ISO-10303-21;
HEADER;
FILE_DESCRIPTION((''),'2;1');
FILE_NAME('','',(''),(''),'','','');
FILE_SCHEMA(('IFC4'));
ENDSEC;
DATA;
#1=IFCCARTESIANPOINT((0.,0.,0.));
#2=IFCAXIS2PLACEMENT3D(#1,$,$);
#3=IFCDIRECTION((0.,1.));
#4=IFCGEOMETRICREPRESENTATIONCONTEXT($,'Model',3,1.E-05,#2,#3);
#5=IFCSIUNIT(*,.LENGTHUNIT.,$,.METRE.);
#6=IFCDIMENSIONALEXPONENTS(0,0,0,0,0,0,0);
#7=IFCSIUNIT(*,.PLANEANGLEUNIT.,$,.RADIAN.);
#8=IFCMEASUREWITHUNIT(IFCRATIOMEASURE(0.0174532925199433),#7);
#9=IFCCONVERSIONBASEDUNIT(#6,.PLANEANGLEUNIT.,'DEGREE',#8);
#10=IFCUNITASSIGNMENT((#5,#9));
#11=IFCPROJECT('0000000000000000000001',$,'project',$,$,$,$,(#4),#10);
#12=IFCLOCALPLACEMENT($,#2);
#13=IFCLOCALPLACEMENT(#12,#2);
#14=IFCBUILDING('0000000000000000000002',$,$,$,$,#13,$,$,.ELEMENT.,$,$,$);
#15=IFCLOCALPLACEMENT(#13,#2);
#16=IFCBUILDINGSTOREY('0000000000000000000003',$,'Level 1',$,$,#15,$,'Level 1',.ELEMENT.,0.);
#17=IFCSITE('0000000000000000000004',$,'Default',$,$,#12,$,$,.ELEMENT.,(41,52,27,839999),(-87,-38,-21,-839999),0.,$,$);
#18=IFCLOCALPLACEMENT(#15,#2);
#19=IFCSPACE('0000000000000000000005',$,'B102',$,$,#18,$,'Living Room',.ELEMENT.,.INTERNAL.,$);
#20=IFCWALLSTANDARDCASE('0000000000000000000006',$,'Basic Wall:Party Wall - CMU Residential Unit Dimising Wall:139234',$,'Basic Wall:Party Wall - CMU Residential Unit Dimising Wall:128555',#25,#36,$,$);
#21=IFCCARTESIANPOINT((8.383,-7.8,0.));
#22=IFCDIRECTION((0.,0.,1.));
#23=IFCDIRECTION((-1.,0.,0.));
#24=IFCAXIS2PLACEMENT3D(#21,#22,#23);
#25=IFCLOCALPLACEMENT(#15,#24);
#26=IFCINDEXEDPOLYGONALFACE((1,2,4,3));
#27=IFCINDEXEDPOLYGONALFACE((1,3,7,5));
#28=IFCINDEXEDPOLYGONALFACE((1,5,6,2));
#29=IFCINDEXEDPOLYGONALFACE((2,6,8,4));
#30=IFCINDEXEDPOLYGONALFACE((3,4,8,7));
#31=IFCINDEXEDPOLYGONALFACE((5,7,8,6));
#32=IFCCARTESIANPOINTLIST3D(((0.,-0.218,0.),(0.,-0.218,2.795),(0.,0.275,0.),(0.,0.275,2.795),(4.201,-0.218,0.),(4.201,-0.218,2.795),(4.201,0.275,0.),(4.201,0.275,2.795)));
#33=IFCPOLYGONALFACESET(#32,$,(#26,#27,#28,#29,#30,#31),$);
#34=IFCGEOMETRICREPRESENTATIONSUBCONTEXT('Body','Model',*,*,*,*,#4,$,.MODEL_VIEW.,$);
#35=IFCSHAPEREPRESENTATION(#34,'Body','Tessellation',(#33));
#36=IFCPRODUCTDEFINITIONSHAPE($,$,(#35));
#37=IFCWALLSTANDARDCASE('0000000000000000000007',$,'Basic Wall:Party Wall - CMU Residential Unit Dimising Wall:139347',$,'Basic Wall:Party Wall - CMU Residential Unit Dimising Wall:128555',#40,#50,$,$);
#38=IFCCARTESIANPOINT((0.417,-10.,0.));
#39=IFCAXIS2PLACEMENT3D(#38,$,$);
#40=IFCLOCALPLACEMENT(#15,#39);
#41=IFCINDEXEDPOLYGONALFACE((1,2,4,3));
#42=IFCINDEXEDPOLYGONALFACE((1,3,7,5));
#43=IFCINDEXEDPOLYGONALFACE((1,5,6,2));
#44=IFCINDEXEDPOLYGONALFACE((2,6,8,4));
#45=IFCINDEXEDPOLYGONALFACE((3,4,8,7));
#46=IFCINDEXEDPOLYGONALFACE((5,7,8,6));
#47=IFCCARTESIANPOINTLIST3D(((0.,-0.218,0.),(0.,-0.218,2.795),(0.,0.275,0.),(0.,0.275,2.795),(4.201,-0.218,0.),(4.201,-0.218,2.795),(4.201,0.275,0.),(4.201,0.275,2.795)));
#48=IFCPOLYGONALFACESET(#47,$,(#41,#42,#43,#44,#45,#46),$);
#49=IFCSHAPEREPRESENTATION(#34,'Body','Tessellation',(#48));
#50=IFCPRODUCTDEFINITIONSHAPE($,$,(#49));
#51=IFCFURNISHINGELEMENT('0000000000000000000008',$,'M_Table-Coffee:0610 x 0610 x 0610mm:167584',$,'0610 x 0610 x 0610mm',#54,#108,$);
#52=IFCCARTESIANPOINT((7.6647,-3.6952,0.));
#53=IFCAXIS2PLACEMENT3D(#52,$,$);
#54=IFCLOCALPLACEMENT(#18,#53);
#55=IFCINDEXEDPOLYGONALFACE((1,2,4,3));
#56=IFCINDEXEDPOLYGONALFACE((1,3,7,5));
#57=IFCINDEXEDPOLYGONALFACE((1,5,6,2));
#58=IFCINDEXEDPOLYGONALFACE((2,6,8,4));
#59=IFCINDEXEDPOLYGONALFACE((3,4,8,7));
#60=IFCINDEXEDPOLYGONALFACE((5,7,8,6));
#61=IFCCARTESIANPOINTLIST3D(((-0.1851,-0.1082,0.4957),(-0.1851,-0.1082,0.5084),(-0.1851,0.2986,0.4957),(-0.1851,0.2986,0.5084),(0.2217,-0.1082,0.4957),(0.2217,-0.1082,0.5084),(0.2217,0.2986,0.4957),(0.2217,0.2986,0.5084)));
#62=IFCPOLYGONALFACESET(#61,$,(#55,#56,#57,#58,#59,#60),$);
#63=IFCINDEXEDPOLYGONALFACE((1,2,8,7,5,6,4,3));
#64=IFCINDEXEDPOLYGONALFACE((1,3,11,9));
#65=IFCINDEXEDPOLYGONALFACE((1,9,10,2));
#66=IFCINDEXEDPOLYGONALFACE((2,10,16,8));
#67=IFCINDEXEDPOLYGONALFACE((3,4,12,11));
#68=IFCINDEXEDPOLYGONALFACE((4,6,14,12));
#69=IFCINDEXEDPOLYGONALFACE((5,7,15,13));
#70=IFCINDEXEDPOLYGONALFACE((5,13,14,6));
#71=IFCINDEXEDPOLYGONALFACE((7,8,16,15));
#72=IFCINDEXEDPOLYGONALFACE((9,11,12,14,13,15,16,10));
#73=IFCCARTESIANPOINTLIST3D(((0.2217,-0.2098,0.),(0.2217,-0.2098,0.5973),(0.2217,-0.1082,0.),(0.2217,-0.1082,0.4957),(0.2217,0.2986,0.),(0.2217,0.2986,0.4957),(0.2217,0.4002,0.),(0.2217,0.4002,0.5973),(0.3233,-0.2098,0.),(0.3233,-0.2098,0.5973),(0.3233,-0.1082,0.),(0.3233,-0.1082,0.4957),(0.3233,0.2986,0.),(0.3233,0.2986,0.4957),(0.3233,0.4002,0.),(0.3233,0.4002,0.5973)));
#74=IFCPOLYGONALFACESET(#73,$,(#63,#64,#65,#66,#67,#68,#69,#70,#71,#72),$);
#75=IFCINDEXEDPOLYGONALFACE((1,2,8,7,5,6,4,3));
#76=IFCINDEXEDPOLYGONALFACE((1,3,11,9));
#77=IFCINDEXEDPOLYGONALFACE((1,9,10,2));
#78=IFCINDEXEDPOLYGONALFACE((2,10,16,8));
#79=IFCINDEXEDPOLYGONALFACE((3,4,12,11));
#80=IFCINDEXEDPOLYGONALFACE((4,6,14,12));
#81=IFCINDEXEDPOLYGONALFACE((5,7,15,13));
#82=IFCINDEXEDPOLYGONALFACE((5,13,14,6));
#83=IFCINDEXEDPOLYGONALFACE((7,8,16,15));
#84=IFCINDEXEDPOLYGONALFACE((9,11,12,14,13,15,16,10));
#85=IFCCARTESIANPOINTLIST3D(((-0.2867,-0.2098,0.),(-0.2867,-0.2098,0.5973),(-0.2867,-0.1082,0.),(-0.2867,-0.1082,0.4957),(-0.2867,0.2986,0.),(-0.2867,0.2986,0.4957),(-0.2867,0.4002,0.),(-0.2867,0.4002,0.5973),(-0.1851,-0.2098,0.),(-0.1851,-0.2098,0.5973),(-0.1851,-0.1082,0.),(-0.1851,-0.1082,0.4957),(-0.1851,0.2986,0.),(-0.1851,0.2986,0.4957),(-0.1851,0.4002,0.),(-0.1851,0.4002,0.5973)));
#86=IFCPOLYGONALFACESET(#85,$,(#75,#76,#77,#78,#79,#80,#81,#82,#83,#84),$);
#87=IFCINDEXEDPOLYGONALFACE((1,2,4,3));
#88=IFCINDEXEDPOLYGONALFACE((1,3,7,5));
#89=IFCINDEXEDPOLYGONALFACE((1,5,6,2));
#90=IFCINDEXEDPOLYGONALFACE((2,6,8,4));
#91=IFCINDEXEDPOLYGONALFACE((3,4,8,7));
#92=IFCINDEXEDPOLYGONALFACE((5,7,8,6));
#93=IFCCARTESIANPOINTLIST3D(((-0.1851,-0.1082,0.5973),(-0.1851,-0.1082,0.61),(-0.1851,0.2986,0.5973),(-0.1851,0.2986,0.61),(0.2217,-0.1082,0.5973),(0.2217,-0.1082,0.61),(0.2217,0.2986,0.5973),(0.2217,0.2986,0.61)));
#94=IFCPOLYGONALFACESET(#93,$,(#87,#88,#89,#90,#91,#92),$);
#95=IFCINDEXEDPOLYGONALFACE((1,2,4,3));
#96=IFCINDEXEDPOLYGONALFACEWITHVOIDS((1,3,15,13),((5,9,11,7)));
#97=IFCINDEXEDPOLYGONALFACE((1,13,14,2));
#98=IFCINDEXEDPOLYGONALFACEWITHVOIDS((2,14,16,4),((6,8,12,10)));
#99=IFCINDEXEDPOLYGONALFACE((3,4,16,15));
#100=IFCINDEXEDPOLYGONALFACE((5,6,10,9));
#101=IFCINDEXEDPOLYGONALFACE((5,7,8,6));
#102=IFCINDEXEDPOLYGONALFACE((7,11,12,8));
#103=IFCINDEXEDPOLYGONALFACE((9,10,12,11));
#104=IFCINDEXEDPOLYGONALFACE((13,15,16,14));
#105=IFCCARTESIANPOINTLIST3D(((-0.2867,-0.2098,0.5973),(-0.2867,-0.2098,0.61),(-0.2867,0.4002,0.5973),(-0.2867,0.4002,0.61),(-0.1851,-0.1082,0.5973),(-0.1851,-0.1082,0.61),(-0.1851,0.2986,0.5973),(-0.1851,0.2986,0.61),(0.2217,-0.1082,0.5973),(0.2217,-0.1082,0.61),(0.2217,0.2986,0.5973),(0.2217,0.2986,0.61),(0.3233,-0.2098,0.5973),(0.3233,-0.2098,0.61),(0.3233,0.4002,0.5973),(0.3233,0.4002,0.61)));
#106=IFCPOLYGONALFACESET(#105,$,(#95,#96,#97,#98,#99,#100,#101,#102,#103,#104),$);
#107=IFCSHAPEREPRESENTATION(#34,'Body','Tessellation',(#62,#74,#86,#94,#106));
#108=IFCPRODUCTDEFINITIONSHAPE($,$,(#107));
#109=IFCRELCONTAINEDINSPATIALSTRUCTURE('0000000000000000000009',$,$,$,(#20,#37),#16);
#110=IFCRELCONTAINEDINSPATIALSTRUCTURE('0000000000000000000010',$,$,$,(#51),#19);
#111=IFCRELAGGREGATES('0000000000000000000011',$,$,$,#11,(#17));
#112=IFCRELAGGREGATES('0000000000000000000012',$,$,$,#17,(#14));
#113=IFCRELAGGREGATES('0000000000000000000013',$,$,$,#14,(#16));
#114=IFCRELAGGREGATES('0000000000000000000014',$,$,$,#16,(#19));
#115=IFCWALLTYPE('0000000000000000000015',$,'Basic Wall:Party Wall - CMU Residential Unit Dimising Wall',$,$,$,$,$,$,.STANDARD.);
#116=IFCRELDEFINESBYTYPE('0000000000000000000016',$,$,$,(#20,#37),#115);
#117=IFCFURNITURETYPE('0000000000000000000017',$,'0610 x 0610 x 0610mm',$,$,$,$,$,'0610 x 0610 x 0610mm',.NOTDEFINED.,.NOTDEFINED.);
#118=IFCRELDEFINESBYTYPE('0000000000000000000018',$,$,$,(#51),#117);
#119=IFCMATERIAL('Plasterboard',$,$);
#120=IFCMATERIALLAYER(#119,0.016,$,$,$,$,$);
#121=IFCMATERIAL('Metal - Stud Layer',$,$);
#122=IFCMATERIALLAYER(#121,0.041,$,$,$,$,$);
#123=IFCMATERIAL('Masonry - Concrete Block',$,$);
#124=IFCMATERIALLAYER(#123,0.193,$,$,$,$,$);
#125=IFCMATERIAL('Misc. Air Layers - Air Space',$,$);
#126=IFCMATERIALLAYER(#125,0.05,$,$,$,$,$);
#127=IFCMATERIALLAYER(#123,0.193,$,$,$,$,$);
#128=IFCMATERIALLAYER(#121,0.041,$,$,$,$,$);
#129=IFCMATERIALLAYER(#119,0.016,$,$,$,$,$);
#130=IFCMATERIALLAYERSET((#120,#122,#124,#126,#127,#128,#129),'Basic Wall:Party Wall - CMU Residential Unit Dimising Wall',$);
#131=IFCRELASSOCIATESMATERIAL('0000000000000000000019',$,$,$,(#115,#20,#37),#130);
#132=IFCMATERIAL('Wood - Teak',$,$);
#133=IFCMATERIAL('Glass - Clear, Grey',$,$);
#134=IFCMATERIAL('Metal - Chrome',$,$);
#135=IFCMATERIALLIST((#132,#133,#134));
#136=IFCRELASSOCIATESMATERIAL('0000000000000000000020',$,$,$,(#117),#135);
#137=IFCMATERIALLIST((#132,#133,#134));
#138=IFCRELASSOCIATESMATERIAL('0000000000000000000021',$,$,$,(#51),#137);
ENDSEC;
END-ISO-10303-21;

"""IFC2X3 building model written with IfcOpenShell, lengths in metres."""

from ifc_helpers import new_model, entity, si_unit, converted_unit, direction, frame, frame_2d, origin, origin_2d_with_axis, place, context, subcontext, project, spatial, polyline, rectangle, outline, extrude, clip, bounded_halfspace, source, transform, mapped, material, material_list, layer, layer_set, layer_usage, type_object, type_shapes, element, save


model = new_model("IFC2X3")

# Units and contexts
model_context = context("Model", 3, precision=1e-05, world=origin(), true_north=direction((0.0, 1.0)))
body_context = subcontext(model_context, "Body", "Model", "MODEL_VIEW")
ifc_project = project(units=[si_unit("LENGTHUNIT", "METRE"), converted_unit("PLANEANGLEUNIT", "DEGREE", entity("IfcRatioMeasure", 0.0174532925199433), si_unit("PLANEANGLEUNIT", "RADIAN"), dimensions=[0, 0, 0, 0, 0, 0, 0])], contexts=[model_context])

# Site, building, storey
site_placement = place(None, origin())
site = spatial("IfcSite", under=ifc_project, at=site_placement, Name="Default", CompositionType="ELEMENT", RefLatitude=(41, 52, 27, 839999), RefLongitude=(-87, -38, -21, -839999), RefElevation=0.0)
building_placement = place(site_placement, origin())
building = spatial("IfcBuilding", under=site, at=building_placement, CompositionType="ELEMENT")
storey_placement = place(building_placement, origin())
storey = spatial("IfcBuildingStorey", under=building, at=storey_placement, Name="Level 1", LongName="Level 1", CompositionType="ELEMENT", Elevation=0.0)

# Shared definitions
ifc_material_1 = material(Name="Plasterboard")
ifc_material_2 = material(Name="Metal - Stud Layer")

# Walls
ifc_layer_1 = layer(ifc_material_1, 0.016)
ifc_layer_2 = layer(ifc_material_2, 0.041)
ifc_material_3 = material(Name="Masonry - Concrete Block")
ifc_layer_3 = layer(ifc_material_3, 0.193)
ifc_material_4 = material(Name="Misc. Air Layers - Air Space")
ifc_layer_4 = layer(ifc_material_4, 0.05)
ifc_layer_5 = layer(ifc_material_3, 0.193)
ifc_layer_6 = layer(ifc_material_2, 0.041)
ifc_layer_7 = layer(ifc_material_1, 0.016)
ifc_layer_set_1 = layer_set([ifc_layer_1, ifc_layer_2, ifc_layer_3, ifc_layer_4, ifc_layer_5, ifc_layer_6, ifc_layer_7], Name="Basic Wall:Party Wall - CMU Residential Unit Dimising Wall")
ifc_layer_usage_1 = layer_usage(ifc_layer_set_1, "AXIS2", "NEGATIVE", 0.275)
wall_type_1 = type_object("IfcWallType", Name="Basic Wall:Party Wall - CMU Residential Unit Dimising Wall", PredefinedType="STANDARD", material=ifc_layer_set_1)
wall_1_placement = place(storey_placement, frame((8.383, -7.8, 0.0), z_axis=(0.0, 0.0, 1.0), x_axis=(-1.0, 0.0, 0.0)))
element("IfcWallStandardCase", 1, at=wall_1_placement, inside=storey, type_object=wall_type_1, material=ifc_layer_usage_1, Name="Basic Wall:Party Wall - CMU Residential Unit Dimising Wall:139234", ObjectType="Basic Wall:Party Wall - CMU Residential Unit Dimising Wall:128555", context=body_context, shape_type="Clipping", body=[
    clip(clip(extrude(rectangle(XDim=4.201, YDim=0.55, at=frame_2d((2.1005, 0.0), x_axis=(-1.0, 0.0))), origin(), (0.0, 0.0, 1.0), 2.795), bounded_halfspace(frame((0.0, -0.218, 2.795), z_axis=(0.0, 1.0, 0.0), x_axis=(-1.0, 0.0, 0.0)), True, frame((0.0, -0.218, 2.795), z_axis=(0.0, 1.0, 0.0), x_axis=(-1.0, 0.0, 0.0)), polyline([(0.0, 0.0), (-3.708, 0.0), (-4.201, 0.0), (-4.201, -2.795), (0.0, -2.795), (0.0, 0.0)]))), bounded_halfspace(frame((4.201, 0.275, 0.0), z_axis=(-1.0, 0.0, 0.0), x_axis=(0.0, -1.0, 0.0)), True, frame((4.201, 0.275, 0.0), z_axis=(-1.0, 0.0, 0.0), x_axis=(0.0, -1.0, 0.0)), polyline([(0.0, 0.0), (0.493, 0.0), (0.493, 2.795), (0.0, 2.795), (0.0, 0.0)]))),
])
ifc_layer_usage_2 = layer_usage(ifc_layer_set_1, "AXIS2", "NEGATIVE", 0.275)
wall_2_placement = place(storey_placement, frame((0.417, -10.0, 0.0)))
element("IfcWallStandardCase", 2, at=wall_2_placement, inside=storey, type_object=wall_type_1, material=ifc_layer_usage_2, Name="Basic Wall:Party Wall - CMU Residential Unit Dimising Wall:139347", ObjectType="Basic Wall:Party Wall - CMU Residential Unit Dimising Wall:128555", context=body_context, shape_type="Clipping", body=[
    clip(clip(extrude(rectangle(XDim=4.201, YDim=0.55, at=frame_2d((2.1005, 0.0), x_axis=(-1.0, 0.0))), origin(), (0.0, 0.0, 1.0), 2.795), bounded_halfspace(frame((0.0, -0.218, 0.0), z_axis=(0.0, 1.0, 0.0), x_axis=(-1.0, 0.0, 0.0)), True, frame((0.0, -0.218, 0.0), z_axis=(0.0, 1.0, 0.0), x_axis=(-1.0, 0.0, 0.0)), polyline([(0.0, 0.0), (0.0, 2.795), (-4.201, 2.795), (-4.201, 0.0), (0.0, 0.0)]))), bounded_halfspace(frame((4.201, 0.275, 0.0), z_axis=(-1.0, 0.0, 0.0), x_axis=(0.0, -1.0, 0.0)), True, frame((4.201, 0.275, 0.0), z_axis=(-1.0, 0.0, 0.0), x_axis=(0.0, -1.0, 0.0)), polyline([(0.0, 0.0), (0.493, 0.0), (0.493, 2.795), (0.0, 2.795), (0.0, 0.0)]))),
])

# Shared definitions
space_1_placement = place(storey_placement, origin())
space_1 = spatial("IfcSpace", under=storey, at=space_1_placement, Name="B102", LongName="Living Room", CompositionType="ELEMENT", InteriorOrExteriorSpace="INTERNAL")

# Furnishing element
ifc_material_5 = material(Name="Wood - Teak")
ifc_material_6 = material(Name="Glass - Clear, Grey")
ifc_material_7 = material(Name="Metal - Chrome")
ifc_material_list_1 = material_list([ifc_material_5, ifc_material_6, ifc_material_7])
ifc_material_list_2 = material_list([ifc_material_5, ifc_material_6, ifc_material_7])
furniture_type_1 = type_object("IfcFurnitureType", Name="0610 x 0610 x 0610mm", ElementType="0610 x 0610 x 0610mm", AssemblyPlace="NOTDEFINED", material=ifc_material_list_2)
shared_shape_1 = source(origin(), body_context, "Body", "SweptSolid", [
    extrude(rectangle(XDim=0.4068, YDim=0.4068, at=origin_2d_with_axis()), frame((0.0183, 0.0952, 0.4957), z_axis=(0.0, 0.0, 1.0), x_axis=(-1.0, 0.0, 0.0)), (0.0, 0.0, 1.0), 0.0127),
    extrude(outline(polyline([(-0.2732, -0.305), (0.324, -0.305), (0.324, 0.305), (-0.2732, 0.305), (-0.2732, 0.2034), (0.2225, 0.2034), (0.2225, -0.2034), (-0.2732, -0.2034), (-0.2732, -0.305)])), frame((0.2217, 0.0952, 0.2732), z_axis=(1.0, 0.0, 0.0), x_axis=(0.0, 0.0, 1.0)), (0.0, 0.0, 1.0), 0.1016),
    extrude(outline(polyline([(-0.305, -0.3241), (0.305, -0.3241), (0.305, 0.2733), (0.2034, 0.2733), (0.2034, -0.2224), (-0.2034, -0.2224), (-0.2034, 0.2733), (-0.305, 0.2733), (-0.305, -0.3241)])), frame((-0.2867, 0.0952, 0.2733), z_axis=(1.0, 0.0, 0.0), x_axis=(0.0, -1.0, 0.0)), (0.0, 0.0, 1.0), 0.1016),
    extrude(rectangle(XDim=0.4068, YDim=0.4068, at=origin_2d_with_axis()), frame((0.0183, 0.0952, 0.5973), z_axis=(0.0, 0.0, 1.0), x_axis=(-1.0, 0.0, 0.0)), (0.0, 0.0, 1.0), 0.0127),
    extrude(outline(polyline([(-0.305, -0.305), (0.305, -0.305), (0.305, 0.305), (-0.305, 0.305), (-0.305, -0.305)]), holes=[polyline([(-0.2034, -0.2034), (-0.2034, 0.2034), (0.2034, 0.2034), (0.2034, -0.2034), (-0.2034, -0.2034)])]), frame((0.0183, 0.0952, 0.5973), z_axis=(0.0, 0.0, 1.0), x_axis=(-1.0, 0.0, 0.0)), (0.0, 0.0, 1.0), 0.0127),
])
type_shapes(furniture_type_1, [shared_shape_1])
furnishing_1_placement = place(space_1_placement, frame((7.6647, -3.6952, 0.0)))
element("IfcFurnishingElement", 3, at=furnishing_1_placement, inside=space_1, type_object=furniture_type_1, material=ifc_material_list_1, Name="M_Table-Coffee:0610 x 0610 x 0610mm:167584", ObjectType="0610 x 0610 x 0610mm", context=body_context, shape_type="MappedRepresentation", body=[
    mapped(shared_shape_1, transform((0.0, 0.0, 0.0), scale=1.0)),
])

save(model, "model.ifc")
